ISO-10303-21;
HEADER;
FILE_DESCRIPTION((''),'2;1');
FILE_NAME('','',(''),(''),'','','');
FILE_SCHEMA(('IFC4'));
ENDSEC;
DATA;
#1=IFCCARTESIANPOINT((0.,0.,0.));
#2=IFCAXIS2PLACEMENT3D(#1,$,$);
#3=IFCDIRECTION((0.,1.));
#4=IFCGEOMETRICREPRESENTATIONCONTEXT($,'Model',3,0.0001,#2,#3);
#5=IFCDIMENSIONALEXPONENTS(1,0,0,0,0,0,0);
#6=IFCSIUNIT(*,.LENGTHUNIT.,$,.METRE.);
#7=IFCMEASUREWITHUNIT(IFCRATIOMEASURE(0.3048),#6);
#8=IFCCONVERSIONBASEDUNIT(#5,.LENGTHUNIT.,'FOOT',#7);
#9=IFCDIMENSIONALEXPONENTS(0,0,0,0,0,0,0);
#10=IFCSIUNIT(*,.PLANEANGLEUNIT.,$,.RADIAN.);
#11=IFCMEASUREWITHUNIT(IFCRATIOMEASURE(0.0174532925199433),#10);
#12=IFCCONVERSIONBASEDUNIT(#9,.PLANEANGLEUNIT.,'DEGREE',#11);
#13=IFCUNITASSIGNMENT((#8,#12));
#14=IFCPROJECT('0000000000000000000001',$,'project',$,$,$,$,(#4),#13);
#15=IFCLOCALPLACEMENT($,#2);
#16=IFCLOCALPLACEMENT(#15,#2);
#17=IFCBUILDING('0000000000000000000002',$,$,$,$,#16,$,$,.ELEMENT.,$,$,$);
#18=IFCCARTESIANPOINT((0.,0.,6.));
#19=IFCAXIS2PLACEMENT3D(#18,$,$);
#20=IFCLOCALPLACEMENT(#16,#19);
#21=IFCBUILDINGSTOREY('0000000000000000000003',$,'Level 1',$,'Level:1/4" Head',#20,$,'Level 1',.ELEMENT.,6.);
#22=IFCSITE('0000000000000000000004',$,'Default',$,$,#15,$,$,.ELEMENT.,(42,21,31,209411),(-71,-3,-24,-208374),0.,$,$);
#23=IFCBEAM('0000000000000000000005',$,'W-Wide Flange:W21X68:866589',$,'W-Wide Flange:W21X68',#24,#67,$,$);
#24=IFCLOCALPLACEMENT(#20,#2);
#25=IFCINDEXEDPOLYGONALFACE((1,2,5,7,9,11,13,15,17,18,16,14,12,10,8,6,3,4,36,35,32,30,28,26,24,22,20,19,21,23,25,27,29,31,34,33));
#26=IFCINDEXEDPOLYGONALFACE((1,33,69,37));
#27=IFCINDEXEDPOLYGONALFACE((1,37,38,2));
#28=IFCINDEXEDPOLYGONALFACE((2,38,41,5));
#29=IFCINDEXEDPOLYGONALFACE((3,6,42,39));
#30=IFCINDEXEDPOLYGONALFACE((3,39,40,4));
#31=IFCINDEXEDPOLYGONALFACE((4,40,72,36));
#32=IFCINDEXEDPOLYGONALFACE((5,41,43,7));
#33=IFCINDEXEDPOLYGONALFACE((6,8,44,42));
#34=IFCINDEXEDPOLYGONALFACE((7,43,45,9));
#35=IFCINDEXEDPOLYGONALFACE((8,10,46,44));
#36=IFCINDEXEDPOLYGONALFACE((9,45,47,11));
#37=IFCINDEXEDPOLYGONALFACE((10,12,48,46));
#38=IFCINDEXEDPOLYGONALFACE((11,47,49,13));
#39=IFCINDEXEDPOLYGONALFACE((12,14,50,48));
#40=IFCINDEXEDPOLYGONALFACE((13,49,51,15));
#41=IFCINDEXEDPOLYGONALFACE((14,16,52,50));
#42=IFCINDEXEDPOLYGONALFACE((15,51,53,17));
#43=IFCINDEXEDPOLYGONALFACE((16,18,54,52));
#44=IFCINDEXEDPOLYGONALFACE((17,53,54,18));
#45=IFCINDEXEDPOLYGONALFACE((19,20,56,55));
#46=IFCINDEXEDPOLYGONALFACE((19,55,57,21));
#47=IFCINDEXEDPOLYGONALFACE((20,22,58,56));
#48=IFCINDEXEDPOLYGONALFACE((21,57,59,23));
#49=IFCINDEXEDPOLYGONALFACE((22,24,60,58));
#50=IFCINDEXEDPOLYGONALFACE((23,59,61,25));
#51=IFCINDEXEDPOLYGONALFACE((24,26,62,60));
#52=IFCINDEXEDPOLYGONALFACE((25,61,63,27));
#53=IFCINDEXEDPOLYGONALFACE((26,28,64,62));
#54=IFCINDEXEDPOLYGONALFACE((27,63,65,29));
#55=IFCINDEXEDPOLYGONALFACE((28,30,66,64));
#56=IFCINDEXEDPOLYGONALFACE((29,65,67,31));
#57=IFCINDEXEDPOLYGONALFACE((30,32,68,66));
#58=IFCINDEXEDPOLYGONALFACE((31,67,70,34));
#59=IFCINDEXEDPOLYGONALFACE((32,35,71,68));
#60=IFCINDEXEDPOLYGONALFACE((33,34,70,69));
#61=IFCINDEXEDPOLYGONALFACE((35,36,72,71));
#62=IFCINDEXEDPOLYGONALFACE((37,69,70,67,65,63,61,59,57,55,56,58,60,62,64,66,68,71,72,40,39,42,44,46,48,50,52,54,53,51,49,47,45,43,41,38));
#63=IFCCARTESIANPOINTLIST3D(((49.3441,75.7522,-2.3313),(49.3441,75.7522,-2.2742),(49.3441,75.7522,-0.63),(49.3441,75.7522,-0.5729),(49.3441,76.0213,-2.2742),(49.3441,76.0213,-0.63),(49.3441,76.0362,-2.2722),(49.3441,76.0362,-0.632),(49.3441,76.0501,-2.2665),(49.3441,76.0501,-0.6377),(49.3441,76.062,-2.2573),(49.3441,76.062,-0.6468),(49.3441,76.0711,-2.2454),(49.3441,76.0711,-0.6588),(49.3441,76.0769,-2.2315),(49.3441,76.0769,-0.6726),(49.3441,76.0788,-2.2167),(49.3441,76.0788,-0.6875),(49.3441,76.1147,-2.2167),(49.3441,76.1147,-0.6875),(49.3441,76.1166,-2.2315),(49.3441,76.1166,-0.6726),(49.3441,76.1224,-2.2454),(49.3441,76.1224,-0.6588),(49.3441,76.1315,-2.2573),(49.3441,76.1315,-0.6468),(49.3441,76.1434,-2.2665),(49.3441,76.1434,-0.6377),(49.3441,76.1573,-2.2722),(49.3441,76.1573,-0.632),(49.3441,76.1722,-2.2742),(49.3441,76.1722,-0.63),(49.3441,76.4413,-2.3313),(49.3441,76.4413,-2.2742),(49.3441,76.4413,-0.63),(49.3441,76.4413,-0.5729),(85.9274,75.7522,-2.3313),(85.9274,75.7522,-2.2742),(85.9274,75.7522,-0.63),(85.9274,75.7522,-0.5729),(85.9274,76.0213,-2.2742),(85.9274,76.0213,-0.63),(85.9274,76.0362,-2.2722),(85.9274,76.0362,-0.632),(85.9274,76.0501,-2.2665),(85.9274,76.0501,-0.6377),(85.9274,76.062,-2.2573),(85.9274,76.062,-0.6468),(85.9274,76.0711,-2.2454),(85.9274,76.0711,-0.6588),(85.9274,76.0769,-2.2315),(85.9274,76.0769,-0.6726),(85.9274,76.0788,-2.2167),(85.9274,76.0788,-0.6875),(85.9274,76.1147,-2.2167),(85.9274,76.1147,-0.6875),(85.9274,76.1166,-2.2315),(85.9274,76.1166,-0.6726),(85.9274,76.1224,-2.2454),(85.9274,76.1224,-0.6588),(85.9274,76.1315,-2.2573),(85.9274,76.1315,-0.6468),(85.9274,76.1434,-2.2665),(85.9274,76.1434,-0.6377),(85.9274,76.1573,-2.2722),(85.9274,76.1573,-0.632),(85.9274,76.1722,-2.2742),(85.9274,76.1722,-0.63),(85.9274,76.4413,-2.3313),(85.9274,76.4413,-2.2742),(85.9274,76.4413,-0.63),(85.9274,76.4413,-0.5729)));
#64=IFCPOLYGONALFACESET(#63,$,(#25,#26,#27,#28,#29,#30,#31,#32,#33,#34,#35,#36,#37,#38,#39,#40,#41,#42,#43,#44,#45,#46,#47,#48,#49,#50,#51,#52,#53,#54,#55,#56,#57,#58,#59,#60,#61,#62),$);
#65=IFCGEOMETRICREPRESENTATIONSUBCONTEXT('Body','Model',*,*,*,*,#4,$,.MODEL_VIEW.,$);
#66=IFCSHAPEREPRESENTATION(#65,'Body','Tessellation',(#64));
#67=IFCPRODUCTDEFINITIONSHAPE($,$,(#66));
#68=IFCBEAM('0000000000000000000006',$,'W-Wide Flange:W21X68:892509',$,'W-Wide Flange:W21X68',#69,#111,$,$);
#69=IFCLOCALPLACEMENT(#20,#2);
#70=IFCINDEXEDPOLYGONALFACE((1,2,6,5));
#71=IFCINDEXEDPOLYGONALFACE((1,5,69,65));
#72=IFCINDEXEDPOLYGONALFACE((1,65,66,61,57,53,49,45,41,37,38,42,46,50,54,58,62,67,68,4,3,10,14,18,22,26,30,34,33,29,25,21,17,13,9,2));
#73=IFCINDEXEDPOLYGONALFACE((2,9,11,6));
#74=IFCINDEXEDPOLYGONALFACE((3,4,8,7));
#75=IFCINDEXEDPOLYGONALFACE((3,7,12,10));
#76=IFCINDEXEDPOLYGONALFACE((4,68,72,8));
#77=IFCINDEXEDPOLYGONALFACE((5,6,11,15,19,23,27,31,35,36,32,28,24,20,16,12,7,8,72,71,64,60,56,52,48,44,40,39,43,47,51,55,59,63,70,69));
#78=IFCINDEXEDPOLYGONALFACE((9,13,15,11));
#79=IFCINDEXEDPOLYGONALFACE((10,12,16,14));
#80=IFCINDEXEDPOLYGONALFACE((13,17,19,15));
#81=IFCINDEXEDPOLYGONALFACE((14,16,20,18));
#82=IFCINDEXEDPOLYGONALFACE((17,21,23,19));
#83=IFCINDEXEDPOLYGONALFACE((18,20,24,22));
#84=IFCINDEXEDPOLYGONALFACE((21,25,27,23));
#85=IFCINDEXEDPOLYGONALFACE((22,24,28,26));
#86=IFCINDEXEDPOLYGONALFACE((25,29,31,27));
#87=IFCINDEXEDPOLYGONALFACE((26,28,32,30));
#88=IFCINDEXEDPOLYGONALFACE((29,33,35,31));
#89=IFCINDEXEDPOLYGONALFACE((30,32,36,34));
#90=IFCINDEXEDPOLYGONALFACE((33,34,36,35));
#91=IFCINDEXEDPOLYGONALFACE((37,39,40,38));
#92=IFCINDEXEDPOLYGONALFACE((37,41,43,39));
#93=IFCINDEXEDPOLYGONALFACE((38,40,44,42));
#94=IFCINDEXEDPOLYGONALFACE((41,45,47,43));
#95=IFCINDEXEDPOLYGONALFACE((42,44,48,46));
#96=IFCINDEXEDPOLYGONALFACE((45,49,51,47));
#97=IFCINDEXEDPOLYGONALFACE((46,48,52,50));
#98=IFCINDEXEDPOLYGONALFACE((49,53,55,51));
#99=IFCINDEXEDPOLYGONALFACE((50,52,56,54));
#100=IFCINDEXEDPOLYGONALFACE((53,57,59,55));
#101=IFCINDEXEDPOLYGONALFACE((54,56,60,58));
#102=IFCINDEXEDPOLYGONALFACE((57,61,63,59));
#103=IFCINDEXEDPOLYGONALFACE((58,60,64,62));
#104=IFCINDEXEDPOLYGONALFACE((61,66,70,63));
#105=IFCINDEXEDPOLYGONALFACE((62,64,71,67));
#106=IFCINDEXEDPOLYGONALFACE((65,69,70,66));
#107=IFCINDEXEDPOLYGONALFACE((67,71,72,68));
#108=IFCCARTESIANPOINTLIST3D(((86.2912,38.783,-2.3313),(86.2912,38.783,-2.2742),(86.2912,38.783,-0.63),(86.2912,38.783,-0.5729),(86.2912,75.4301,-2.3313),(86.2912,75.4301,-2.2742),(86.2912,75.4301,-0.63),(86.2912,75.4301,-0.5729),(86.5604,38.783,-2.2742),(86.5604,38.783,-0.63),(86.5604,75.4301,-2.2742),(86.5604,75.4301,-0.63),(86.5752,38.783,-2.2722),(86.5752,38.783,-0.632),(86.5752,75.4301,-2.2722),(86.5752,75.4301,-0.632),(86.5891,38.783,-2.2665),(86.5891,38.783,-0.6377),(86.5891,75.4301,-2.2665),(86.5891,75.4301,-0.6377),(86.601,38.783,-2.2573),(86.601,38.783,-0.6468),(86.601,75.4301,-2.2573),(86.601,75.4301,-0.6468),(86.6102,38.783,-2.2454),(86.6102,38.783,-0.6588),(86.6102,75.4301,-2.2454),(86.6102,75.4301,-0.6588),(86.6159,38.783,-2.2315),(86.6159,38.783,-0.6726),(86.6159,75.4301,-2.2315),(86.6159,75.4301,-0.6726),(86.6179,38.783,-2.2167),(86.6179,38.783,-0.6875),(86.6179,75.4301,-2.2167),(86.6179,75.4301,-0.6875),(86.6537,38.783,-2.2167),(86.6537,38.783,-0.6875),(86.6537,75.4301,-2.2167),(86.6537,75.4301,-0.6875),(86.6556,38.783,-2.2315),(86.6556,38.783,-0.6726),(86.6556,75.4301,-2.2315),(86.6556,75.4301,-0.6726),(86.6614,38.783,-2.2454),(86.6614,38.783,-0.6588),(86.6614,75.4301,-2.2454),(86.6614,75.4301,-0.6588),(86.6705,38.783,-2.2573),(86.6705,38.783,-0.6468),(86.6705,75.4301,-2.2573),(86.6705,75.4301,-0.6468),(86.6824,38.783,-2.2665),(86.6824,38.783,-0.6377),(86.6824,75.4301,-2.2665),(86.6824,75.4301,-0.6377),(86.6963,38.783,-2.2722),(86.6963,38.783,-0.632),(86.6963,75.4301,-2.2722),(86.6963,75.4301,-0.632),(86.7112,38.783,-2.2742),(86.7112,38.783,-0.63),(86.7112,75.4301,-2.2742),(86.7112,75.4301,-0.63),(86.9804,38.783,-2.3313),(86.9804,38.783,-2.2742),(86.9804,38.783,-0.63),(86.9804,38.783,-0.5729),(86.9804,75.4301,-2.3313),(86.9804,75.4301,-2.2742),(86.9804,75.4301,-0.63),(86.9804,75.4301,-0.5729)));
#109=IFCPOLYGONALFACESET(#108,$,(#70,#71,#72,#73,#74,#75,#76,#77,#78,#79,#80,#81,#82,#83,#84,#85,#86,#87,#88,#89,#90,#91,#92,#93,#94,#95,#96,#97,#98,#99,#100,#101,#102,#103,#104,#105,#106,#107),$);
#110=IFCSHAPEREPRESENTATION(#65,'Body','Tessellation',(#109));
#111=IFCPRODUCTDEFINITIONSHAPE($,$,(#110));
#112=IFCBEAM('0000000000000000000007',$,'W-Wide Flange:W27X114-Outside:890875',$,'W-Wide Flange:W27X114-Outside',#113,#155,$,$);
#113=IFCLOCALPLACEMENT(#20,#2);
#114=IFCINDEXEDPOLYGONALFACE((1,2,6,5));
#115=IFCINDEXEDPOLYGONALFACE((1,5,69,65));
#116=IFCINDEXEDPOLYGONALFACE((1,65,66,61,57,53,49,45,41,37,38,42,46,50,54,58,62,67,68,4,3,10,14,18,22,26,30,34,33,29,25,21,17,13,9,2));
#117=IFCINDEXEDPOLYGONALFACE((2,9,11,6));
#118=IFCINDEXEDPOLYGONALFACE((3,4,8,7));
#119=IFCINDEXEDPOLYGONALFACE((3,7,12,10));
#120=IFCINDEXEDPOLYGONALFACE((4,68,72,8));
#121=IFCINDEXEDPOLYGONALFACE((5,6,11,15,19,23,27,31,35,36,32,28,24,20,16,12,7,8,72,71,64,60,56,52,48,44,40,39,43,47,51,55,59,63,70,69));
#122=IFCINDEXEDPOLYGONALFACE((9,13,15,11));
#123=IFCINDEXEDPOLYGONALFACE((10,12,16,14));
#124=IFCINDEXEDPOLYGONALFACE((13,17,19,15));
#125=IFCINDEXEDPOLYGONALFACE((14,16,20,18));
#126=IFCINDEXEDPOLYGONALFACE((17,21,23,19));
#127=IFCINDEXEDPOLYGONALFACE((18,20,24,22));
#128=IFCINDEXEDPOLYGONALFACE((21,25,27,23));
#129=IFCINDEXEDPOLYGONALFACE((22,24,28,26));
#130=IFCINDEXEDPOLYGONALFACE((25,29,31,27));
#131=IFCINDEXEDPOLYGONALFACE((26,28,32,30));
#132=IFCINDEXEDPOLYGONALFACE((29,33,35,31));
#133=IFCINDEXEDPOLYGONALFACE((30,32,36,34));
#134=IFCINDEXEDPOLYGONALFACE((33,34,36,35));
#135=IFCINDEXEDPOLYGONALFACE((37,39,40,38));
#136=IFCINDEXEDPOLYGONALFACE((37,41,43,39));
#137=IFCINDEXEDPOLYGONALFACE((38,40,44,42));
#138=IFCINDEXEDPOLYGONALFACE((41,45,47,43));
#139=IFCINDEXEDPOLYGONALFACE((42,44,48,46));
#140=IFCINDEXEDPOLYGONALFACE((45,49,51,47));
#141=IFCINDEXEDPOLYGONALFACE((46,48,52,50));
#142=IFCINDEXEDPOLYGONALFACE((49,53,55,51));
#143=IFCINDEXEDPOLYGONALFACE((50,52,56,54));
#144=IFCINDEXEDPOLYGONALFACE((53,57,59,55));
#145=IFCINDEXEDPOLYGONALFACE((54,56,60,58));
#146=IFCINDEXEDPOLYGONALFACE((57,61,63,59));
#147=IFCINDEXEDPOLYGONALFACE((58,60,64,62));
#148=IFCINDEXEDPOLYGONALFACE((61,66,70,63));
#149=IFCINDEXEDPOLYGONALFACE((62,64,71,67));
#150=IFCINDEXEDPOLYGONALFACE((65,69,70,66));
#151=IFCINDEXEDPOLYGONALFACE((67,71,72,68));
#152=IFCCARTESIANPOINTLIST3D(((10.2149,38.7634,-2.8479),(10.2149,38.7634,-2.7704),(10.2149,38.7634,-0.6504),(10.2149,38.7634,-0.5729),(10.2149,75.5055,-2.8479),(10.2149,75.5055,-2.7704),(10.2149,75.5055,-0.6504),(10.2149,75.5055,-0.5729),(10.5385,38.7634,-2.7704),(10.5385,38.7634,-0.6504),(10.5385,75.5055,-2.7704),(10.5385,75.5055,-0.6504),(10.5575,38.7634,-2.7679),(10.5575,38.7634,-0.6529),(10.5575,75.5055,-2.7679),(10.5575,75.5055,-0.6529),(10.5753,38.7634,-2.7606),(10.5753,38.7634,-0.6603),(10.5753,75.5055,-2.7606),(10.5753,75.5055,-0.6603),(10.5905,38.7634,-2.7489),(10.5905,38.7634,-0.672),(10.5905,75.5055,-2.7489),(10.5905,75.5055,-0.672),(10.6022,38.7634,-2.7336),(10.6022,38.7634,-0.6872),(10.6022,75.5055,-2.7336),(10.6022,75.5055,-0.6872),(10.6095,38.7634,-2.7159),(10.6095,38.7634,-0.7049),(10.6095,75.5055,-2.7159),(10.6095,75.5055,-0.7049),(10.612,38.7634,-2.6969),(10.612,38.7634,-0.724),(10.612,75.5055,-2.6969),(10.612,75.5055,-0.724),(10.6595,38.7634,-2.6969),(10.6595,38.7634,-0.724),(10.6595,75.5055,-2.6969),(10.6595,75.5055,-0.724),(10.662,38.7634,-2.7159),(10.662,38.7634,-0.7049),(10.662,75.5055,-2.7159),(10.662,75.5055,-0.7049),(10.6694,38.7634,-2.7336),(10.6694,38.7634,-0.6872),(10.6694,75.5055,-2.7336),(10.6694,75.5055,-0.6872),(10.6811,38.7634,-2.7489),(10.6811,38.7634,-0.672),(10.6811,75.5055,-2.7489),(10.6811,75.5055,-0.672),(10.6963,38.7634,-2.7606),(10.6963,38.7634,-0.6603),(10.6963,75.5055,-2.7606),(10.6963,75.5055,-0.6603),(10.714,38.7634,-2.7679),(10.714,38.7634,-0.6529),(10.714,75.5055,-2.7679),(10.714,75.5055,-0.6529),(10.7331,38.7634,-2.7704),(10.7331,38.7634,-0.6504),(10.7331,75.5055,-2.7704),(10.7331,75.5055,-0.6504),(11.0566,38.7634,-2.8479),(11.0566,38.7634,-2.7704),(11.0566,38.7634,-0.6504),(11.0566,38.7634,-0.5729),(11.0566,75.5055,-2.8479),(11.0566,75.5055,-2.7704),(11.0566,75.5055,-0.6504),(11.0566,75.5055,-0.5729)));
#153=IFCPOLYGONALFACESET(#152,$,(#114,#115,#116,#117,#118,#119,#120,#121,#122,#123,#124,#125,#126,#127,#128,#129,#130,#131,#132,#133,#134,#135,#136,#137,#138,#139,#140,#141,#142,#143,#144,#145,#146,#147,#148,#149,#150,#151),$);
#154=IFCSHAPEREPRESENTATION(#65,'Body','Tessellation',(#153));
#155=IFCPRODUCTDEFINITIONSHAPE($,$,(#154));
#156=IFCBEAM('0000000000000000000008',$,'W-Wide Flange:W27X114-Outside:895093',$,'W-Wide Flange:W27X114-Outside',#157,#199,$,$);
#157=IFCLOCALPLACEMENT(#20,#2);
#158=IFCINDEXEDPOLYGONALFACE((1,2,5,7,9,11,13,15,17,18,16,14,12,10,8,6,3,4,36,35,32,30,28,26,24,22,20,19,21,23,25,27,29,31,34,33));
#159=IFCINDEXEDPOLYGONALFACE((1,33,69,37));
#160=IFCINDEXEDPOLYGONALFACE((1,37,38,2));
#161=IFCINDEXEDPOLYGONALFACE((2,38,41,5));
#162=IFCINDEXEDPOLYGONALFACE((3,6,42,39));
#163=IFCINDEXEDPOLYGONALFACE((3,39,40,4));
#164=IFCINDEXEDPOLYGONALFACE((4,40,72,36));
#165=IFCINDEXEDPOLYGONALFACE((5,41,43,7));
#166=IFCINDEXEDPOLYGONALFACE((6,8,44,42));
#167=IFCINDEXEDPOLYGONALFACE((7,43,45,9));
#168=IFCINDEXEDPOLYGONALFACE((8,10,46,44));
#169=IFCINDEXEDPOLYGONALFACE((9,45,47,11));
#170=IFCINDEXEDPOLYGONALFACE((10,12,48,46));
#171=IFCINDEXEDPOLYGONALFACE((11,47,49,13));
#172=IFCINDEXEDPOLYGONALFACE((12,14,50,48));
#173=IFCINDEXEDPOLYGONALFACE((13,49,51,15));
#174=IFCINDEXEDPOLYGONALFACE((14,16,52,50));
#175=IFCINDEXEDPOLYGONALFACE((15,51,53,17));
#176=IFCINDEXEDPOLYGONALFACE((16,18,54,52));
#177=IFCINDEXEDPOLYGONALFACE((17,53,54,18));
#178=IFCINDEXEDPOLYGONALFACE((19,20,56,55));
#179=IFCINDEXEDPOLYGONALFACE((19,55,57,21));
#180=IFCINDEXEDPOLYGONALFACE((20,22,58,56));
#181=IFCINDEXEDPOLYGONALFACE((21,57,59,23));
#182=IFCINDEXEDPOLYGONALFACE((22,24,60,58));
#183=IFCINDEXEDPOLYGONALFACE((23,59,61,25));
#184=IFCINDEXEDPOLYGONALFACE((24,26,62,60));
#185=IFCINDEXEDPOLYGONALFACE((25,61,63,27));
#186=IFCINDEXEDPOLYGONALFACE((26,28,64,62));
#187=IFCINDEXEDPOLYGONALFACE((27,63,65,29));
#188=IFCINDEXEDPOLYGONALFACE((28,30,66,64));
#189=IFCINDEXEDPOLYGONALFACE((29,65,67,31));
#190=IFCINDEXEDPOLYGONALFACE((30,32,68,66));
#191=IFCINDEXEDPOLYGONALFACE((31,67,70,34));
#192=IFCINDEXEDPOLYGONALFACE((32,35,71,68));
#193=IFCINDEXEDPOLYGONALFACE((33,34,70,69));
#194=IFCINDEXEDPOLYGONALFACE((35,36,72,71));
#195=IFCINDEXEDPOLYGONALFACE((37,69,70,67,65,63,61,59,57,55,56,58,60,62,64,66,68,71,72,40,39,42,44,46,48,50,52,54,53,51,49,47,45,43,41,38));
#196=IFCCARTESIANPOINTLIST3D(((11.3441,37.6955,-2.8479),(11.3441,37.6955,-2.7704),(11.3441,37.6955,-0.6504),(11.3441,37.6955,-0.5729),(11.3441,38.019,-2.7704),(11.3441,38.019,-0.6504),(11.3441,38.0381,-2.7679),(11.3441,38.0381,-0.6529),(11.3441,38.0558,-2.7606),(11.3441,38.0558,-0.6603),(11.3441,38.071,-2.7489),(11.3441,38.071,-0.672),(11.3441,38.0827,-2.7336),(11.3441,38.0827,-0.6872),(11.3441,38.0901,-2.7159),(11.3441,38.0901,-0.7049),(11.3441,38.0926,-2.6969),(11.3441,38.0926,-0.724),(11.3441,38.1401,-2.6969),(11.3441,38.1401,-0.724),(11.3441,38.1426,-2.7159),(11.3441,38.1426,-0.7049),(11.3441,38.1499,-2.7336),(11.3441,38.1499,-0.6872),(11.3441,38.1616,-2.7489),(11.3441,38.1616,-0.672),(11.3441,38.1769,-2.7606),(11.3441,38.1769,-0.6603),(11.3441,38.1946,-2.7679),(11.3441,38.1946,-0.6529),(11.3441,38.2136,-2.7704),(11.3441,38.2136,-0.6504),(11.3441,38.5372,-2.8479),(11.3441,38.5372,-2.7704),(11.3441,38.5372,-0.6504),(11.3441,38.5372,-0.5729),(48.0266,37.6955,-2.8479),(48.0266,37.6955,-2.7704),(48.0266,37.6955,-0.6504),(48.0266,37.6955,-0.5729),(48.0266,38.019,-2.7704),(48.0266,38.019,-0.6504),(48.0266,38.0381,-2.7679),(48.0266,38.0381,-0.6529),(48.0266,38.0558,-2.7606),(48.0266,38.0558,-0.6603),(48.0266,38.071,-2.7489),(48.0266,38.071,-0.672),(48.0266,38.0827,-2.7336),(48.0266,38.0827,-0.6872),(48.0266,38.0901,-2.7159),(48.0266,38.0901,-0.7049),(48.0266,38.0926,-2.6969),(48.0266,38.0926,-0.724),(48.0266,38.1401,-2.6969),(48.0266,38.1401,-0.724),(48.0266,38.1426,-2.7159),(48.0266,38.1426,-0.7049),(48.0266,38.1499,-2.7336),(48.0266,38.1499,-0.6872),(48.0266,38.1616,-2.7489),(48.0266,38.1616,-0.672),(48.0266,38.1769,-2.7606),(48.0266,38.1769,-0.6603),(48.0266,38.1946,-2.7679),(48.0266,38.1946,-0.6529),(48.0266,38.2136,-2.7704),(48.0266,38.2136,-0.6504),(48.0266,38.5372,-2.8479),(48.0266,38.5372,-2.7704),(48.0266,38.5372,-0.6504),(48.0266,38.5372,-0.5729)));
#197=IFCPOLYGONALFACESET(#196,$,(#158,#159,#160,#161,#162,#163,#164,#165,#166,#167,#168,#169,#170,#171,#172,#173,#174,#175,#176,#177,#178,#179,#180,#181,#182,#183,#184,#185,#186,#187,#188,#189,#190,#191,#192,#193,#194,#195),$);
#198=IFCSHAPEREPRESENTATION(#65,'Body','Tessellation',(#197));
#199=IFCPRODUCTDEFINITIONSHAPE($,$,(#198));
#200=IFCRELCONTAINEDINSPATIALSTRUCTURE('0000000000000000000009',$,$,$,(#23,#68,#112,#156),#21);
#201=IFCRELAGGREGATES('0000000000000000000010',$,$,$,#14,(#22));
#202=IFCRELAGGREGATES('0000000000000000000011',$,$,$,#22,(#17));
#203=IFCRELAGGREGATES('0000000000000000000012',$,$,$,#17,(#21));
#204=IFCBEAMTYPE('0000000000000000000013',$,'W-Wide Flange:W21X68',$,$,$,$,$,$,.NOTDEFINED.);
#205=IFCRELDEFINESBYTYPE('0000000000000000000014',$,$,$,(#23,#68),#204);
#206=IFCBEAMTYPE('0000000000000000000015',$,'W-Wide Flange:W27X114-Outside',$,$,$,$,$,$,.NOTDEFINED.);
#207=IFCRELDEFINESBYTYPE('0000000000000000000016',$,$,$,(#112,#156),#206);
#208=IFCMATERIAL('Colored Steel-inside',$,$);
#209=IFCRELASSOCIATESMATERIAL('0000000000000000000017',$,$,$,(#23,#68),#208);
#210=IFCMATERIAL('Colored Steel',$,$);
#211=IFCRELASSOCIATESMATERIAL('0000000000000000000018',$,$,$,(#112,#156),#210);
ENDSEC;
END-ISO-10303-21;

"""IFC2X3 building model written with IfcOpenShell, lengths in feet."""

from ifc_helpers import new_model, entity, si_unit, converted_unit, direction, frame, frame_2d, origin, place, context, subcontext, project, spatial, i_section, extrude, material, type_object, element, save


model = new_model("IFC2X3")

# Units and contexts
model_context = context("Model", 3, precision=0.0001, world=origin(), true_north=direction((0.0, 1.0)))
body_context = subcontext(model_context, "Body", "Model", "MODEL_VIEW")
ifc_project = project(units=[converted_unit("LENGTHUNIT", "FOOT", entity("IfcRatioMeasure", 0.3048), si_unit("LENGTHUNIT", "METRE"), dimensions=[1, 0, 0, 0, 0, 0, 0]), converted_unit("PLANEANGLEUNIT", "DEGREE", entity("IfcRatioMeasure", 0.0174532925199433), si_unit("PLANEANGLEUNIT", "RADIAN"), dimensions=[0, 0, 0, 0, 0, 0, 0])], contexts=[model_context])

# Site, building, storey
site_placement = place(None, origin())
site = spatial("IfcSite", under=ifc_project, at=site_placement, Name="Default", CompositionType="ELEMENT", RefLatitude=(42, 21, 31, 209411), RefLongitude=(-71, -3, -24, -208374), RefElevation=0.0)
building_placement = place(site_placement, origin())
building = spatial("IfcBuilding", under=site, at=building_placement, CompositionType="ELEMENT")
storey_placement = place(building_placement, frame((0.0, 0.0, 6.0)))
storey = spatial("IfcBuildingStorey", under=building, at=storey_placement, Name="Level 1", ObjectType="Level:1/4\" Head", LongName="Level 1", CompositionType="ELEMENT", Elevation=6.0)

# Shared definitions
ifc_material_1 = material(Name="Colored Steel-inside")

# Beams
beam_type_1 = type_object("IfcBeamType", Name="W-Wide Flange:W21X68", PredefinedType="NOTDEFINED")
beam_1_placement = place(storey_placement, frame((86.6554, 76.0968, 0.0), z_axis=(0.0, 0.0, 1.0), x_axis=(-1.0, 0.0, 0.0)))
element("IfcBeam", 1, at=beam_1_placement, inside=storey, type_object=beam_type_1, material=ifc_material_1, Name="W-Wide Flange:W21X68:866589", ObjectType="W-Wide Flange:W21X68", context=body_context, shape_type="SweptSolid", body=[
    extrude(i_section(OverallWidth=0.6892, OverallDepth=1.7583, WebThickness=0.0358, FlangeThickness=0.0571, FilletRadius=0.0575, at=frame_2d((0.0, 0.0), x_axis=(0.0, 1.0))), frame((0.7279, 0.0, -1.4521), z_axis=(1.0, 0.0, 0.0), x_axis=(0.0, 0.0, -1.0)), (0.0, 0.0, 1.0), 36.5833),
])
beam_2_placement = place(storey_placement, frame((86.6358, 76.0968, 0.0), z_axis=(0.0, 0.0, 1.0), x_axis=(0.0, -1.0, 0.0)))
element("IfcBeam", 2, at=beam_2_placement, inside=storey, type_object=beam_type_1, material=ifc_material_1, Name="W-Wide Flange:W21X68:892509", ObjectType="W-Wide Flange:W21X68", context=body_context, shape_type="SweptSolid", body=[
    extrude(i_section(OverallWidth=0.6892, OverallDepth=1.7583, WebThickness=0.0358, FlangeThickness=0.0571, FilletRadius=0.0575, at=frame_2d((0.0, 0.0), x_axis=(0.0, 1.0))), frame((0.6667, 0.0, -1.4521), z_axis=(1.0, 0.0, 0.0), x_axis=(0.0, 0.0, -1.0)), (0.0, 0.0, 1.0), 36.6471),
])
ifc_material_2 = material(Name="Colored Steel")
beam_type_2 = type_object("IfcBeamType", Name="W-Wide Flange:W27X114-Outside", PredefinedType="NOTDEFINED")
beam_3_placement = place(storey_placement, frame((10.6358, 76.0968, 0.0), z_axis=(0.0, 0.0, 1.0), x_axis=(0.0, -1.0, 0.0)))
element("IfcBeam", 3, at=beam_3_placement, inside=storey, type_object=beam_type_2, material=ifc_material_2, Name="W-Wide Flange:W27X114-Outside:890875", ObjectType="W-Wide Flange:W27X114-Outside", context=body_context, shape_type="SweptSolid", body=[
    extrude(i_section(OverallWidth=0.8417, OverallDepth=2.275, WebThickness=0.0475, FlangeThickness=0.0775, FilletRadius=0.0735, at=frame_2d((0.0, 0.0), x_axis=(0.0, 1.0))), frame((0.5912, 0.0, -1.7104), z_axis=(1.0, 0.0, 0.0), x_axis=(0.0, 0.0, -1.0)), (0.0, 0.0, 1.0), 36.7421),
])
beam_4_placement = place(storey_placement, frame((10.6358, 38.1163, 0.0)))
element("IfcBeam", 4, at=beam_4_placement, inside=storey, type_object=beam_type_2, material=ifc_material_2, Name="W-Wide Flange:W27X114-Outside:895093", ObjectType="W-Wide Flange:W27X114-Outside", context=body_context, shape_type="SweptSolid", body=[
    extrude(i_section(OverallWidth=0.8417, OverallDepth=2.275, WebThickness=0.0475, FlangeThickness=0.0775, FilletRadius=0.0735, at=frame_2d((0.0, 0.0), x_axis=(0.0, 1.0))), frame((0.7083, 0.0, -1.7104), z_axis=(1.0, 0.0, 0.0), x_axis=(0.0, 0.0, -1.0)), (0.0, 0.0, 1.0), 36.6825),
])

save(model, "model.ifc")
